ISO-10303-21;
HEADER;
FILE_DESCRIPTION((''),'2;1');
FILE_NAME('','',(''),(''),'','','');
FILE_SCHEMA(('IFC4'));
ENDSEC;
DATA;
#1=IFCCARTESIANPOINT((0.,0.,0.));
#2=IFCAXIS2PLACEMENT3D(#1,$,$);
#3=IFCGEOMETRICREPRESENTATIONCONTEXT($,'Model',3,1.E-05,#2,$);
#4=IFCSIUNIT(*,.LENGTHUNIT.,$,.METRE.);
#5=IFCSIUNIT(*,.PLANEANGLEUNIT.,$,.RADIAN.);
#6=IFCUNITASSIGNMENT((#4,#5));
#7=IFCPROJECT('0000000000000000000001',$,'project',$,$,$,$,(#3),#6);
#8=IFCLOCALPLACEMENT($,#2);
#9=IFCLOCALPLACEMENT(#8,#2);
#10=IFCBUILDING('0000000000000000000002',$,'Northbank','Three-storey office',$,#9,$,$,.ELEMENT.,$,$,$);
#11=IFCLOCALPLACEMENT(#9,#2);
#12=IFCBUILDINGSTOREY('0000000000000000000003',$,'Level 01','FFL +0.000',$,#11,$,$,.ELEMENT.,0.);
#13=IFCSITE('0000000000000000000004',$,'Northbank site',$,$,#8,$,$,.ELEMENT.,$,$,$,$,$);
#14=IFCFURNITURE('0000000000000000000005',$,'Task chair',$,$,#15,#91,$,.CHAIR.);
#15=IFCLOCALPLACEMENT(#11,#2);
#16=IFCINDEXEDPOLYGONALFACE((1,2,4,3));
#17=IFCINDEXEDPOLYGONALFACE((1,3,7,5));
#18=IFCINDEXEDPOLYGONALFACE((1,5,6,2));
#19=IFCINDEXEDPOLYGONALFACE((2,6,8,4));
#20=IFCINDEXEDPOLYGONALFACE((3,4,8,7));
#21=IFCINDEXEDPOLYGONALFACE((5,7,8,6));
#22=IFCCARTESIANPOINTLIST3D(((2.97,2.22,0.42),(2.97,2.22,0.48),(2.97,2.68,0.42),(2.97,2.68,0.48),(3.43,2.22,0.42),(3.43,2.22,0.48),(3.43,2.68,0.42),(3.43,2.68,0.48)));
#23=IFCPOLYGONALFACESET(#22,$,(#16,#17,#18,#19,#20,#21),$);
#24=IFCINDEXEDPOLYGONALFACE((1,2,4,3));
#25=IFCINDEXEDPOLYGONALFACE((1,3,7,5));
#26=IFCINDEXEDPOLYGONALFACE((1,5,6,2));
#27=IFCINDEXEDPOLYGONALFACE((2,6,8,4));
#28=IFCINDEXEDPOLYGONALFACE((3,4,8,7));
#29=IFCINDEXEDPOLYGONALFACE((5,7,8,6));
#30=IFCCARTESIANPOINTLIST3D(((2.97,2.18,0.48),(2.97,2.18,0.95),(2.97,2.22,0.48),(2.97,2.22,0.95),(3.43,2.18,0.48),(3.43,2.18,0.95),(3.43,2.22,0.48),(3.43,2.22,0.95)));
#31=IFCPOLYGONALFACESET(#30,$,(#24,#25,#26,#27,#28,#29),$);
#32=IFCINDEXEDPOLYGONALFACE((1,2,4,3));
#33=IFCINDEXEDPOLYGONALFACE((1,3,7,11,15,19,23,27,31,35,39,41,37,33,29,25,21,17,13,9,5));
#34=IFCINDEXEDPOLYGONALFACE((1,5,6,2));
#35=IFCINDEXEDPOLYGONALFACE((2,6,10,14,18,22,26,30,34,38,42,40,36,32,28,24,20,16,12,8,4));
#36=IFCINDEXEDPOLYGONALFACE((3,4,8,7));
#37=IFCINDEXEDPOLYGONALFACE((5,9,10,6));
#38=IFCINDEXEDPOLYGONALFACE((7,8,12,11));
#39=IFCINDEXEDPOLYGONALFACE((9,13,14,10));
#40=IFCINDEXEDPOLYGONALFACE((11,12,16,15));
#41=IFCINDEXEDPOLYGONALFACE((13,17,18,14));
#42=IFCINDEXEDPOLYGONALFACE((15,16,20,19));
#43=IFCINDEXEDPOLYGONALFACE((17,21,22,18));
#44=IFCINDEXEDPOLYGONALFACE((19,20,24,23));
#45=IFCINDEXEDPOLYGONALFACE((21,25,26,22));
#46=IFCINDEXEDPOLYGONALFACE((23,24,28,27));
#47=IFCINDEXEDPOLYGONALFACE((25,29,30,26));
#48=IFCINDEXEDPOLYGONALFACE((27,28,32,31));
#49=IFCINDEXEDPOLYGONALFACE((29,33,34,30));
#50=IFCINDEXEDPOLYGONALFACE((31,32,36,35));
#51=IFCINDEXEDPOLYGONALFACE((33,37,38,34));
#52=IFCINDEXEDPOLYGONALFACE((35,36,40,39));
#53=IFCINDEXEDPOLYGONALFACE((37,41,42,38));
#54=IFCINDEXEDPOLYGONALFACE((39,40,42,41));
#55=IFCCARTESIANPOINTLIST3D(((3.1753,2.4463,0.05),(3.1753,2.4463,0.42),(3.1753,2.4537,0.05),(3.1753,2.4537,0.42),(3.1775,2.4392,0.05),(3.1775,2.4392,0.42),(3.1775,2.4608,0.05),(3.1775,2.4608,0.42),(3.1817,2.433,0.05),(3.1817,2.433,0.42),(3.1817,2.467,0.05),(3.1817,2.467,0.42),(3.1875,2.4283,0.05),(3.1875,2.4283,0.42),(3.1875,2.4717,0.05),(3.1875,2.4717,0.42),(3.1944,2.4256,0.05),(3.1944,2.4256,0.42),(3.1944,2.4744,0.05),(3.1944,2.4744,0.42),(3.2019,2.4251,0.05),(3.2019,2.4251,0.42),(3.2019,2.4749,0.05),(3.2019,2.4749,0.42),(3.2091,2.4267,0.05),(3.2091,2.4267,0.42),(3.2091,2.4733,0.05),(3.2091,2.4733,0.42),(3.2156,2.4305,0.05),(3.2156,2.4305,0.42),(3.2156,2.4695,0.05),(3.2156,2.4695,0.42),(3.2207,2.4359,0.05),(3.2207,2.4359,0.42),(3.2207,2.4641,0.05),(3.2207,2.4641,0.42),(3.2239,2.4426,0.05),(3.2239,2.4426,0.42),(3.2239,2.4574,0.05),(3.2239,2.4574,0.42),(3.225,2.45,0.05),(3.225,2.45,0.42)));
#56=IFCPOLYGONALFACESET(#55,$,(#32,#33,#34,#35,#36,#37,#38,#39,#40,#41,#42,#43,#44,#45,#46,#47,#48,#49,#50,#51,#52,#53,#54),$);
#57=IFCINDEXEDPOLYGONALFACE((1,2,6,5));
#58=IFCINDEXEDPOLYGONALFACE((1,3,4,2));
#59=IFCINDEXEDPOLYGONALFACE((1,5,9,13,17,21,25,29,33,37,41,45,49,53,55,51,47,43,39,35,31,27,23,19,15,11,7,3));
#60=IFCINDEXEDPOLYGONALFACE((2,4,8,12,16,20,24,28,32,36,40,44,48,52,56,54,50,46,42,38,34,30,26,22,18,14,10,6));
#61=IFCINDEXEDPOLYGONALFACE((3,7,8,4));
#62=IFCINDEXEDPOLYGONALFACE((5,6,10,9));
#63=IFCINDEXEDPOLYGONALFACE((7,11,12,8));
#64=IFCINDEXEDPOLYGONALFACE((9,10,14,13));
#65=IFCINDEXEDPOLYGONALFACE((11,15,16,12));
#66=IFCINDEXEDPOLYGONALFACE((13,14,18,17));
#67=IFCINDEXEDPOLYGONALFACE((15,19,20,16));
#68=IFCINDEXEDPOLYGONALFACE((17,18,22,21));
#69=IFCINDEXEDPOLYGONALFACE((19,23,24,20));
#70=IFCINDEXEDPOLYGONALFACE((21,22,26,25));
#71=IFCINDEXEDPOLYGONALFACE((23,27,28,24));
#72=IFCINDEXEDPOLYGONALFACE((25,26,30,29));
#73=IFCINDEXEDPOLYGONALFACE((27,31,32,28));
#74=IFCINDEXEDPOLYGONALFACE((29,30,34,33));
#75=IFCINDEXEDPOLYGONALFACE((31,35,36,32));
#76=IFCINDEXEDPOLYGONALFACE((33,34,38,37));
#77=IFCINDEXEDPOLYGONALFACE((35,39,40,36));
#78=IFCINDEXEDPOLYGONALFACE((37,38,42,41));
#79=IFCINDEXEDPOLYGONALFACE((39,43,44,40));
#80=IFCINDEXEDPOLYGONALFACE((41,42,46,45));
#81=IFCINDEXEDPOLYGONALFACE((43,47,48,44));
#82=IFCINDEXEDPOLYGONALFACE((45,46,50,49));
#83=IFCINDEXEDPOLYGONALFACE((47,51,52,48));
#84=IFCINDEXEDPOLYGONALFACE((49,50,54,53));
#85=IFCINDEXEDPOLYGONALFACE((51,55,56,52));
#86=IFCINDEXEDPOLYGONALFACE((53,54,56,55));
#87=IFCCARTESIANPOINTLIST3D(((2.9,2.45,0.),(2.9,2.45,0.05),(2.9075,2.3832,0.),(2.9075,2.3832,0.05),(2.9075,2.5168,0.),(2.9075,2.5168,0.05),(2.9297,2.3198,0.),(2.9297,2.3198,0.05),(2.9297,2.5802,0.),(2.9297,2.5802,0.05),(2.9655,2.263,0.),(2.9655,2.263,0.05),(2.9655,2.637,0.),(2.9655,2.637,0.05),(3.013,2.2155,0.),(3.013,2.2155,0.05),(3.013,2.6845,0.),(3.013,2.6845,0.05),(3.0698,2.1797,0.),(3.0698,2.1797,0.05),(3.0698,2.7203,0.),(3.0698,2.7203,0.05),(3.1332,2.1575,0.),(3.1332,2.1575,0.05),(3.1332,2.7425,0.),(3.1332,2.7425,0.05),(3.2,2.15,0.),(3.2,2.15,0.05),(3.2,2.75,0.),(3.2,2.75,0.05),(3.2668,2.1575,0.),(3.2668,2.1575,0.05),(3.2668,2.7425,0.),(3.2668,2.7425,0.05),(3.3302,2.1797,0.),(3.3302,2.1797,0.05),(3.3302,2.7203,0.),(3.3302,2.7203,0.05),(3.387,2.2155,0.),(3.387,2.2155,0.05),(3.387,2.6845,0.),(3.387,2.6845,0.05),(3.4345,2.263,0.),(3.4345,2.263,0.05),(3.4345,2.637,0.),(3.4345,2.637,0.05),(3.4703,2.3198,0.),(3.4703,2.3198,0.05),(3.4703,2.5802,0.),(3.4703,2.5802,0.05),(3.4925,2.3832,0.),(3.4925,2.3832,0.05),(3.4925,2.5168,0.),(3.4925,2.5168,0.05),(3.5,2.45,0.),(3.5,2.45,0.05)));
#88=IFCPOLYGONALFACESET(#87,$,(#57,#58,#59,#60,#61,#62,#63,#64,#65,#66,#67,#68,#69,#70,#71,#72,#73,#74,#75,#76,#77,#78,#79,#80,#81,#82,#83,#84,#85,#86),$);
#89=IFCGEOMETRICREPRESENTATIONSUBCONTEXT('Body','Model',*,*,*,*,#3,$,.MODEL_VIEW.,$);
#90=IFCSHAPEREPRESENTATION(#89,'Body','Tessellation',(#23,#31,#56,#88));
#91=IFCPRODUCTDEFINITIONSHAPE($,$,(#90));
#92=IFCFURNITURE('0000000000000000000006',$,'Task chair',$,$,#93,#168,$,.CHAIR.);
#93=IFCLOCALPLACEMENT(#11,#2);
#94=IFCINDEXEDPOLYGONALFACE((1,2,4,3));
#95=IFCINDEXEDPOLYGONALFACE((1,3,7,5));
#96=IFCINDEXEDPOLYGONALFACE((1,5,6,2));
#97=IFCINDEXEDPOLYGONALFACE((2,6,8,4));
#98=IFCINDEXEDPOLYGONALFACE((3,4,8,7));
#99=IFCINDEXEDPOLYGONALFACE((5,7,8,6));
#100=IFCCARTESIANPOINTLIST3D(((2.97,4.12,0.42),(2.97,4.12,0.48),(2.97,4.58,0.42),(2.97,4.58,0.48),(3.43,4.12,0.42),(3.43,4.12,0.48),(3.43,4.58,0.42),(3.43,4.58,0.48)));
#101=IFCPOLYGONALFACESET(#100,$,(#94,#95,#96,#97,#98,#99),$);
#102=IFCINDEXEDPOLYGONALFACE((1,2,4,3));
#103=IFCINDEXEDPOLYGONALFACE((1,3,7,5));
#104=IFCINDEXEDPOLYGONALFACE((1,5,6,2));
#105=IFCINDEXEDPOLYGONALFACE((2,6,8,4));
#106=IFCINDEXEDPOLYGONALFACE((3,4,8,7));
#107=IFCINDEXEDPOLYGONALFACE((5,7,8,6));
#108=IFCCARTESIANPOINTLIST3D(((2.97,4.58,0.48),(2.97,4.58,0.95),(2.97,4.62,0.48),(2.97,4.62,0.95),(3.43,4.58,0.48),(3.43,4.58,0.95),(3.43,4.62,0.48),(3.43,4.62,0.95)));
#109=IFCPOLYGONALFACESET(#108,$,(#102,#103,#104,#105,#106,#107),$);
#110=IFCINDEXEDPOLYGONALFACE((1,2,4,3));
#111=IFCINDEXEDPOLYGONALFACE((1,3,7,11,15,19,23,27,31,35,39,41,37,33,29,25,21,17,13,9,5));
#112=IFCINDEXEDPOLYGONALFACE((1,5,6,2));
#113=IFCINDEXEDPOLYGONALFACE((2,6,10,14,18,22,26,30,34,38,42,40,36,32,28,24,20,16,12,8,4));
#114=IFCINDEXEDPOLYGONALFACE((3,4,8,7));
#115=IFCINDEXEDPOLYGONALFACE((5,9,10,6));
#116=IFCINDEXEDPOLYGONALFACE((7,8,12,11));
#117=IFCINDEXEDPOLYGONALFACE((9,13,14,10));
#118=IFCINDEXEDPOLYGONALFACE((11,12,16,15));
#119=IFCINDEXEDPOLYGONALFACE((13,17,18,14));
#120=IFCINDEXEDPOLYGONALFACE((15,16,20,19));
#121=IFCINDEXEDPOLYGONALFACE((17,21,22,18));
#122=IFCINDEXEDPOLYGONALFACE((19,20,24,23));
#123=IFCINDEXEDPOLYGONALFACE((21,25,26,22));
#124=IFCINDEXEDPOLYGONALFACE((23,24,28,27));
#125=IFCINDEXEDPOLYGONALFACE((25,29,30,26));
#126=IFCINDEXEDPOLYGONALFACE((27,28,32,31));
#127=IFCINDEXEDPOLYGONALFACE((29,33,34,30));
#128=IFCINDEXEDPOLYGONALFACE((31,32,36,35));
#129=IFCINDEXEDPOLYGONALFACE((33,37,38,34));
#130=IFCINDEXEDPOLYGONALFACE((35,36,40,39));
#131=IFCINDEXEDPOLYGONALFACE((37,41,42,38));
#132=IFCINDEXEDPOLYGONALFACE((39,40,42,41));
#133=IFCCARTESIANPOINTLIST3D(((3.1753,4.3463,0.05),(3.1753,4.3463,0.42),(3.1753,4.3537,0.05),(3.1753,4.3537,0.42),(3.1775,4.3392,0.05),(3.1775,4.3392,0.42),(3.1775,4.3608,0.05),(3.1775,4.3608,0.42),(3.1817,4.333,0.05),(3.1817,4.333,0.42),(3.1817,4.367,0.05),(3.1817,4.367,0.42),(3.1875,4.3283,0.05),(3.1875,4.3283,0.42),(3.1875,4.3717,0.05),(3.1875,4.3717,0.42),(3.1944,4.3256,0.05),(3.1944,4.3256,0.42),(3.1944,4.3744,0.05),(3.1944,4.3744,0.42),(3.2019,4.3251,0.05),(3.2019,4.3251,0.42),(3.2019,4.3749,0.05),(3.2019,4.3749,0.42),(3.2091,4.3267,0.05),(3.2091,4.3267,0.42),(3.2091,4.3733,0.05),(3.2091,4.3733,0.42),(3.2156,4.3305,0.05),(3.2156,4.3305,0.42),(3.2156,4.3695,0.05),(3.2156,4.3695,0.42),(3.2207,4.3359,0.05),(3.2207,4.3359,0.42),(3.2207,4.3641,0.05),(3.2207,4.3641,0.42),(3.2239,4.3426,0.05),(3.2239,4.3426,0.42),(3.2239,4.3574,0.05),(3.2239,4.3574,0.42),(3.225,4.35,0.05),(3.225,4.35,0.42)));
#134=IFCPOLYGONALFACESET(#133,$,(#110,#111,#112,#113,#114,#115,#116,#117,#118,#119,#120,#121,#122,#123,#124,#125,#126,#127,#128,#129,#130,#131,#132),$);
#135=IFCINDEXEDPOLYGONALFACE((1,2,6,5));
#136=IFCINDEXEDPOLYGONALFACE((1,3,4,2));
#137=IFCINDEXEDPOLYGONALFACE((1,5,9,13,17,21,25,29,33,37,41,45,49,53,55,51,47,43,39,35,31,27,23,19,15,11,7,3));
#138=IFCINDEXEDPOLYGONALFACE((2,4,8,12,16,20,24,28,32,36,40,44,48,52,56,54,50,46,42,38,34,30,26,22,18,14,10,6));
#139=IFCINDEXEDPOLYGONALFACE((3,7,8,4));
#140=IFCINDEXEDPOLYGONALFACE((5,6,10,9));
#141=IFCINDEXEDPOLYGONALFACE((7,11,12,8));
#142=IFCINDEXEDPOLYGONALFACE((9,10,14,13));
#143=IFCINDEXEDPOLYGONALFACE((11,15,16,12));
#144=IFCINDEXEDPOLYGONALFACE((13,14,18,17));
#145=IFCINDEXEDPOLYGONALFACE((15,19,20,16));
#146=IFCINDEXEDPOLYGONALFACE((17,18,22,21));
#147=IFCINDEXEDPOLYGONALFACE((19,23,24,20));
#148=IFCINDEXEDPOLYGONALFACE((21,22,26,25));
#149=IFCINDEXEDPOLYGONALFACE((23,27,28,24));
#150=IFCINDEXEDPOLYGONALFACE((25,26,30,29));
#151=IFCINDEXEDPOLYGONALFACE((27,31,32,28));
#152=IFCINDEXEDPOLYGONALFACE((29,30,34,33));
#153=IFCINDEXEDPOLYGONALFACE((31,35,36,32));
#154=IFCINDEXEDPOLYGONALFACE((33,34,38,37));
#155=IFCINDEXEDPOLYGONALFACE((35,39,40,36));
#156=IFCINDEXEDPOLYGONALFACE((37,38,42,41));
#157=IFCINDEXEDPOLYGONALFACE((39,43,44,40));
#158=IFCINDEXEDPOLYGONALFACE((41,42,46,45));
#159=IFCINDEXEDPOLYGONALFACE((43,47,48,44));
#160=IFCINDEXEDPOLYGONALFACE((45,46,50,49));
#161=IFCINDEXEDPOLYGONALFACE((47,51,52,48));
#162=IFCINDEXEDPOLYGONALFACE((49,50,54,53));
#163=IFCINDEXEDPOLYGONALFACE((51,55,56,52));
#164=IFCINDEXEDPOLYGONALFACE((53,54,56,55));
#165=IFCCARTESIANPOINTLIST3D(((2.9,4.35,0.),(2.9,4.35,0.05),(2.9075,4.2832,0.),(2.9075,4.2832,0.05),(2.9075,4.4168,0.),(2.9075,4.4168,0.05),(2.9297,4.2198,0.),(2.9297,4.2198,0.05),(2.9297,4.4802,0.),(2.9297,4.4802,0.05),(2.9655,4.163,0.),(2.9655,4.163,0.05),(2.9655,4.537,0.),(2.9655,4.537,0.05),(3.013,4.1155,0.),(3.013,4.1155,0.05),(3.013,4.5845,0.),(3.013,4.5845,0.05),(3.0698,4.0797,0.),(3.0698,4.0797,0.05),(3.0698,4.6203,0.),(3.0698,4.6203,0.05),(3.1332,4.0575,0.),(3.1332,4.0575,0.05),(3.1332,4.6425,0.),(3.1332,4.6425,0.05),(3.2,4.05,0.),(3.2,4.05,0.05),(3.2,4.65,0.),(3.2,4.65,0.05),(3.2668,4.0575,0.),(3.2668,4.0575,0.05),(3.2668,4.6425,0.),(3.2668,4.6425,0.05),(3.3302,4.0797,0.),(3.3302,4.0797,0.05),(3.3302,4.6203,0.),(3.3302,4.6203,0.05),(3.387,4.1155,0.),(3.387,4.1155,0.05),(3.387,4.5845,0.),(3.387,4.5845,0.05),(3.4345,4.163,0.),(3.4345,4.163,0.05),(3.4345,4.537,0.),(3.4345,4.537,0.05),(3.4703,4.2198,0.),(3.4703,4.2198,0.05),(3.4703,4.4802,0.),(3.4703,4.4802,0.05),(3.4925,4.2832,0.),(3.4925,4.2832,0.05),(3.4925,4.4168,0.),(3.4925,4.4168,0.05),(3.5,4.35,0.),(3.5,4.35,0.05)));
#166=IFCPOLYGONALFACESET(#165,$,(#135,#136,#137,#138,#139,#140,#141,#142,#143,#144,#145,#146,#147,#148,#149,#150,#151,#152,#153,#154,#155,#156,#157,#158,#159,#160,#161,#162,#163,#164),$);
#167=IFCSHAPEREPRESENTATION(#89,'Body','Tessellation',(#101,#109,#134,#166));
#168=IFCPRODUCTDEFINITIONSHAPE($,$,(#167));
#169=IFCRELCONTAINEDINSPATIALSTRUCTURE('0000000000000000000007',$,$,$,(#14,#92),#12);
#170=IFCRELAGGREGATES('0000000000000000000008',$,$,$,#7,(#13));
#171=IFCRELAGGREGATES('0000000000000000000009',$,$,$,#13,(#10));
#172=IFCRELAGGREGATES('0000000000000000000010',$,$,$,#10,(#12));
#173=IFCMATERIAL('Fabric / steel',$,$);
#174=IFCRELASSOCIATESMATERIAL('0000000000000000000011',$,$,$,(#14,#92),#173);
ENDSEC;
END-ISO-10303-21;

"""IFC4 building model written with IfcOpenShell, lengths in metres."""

from ifc_helpers import new_model, si_unit, frame, origin, place, context, subcontext, project, spatial, rectangle, circle, extrude, material, element, save


model = new_model("IFC4")

# Units and contexts
model_context = context("Model", 3, precision=1e-05, world=origin())
body_context = subcontext(model_context, "Body", "Model", "MODEL_VIEW")
ifc_project = project(units=[si_unit("LENGTHUNIT", "METRE"), si_unit("PLANEANGLEUNIT", "RADIAN")], contexts=[model_context])

# Site, building, storey
site_placement = place(None, origin())
site = spatial("IfcSite", under=ifc_project, at=site_placement, Name="Northbank site", CompositionType="ELEMENT")
building_placement = place(site_placement, origin())
building = spatial("IfcBuilding", under=site, at=building_placement, Name="Northbank", Description="Three-storey office", CompositionType="ELEMENT")
storey_placement = place(building_placement, origin())
storey = spatial("IfcBuildingStorey", under=building, at=storey_placement, Name="Level 01", Description="FFL +0.000", CompositionType="ELEMENT", Elevation=0.0)

# Furniture
ifc_material_1 = material(Name="Fabric / steel")
furniture_1_placement = place(storey_placement, origin())
element("IfcFurniture", 1, at=furniture_1_placement, inside=storey, material=ifc_material_1, Name="Task chair", PredefinedType="CHAIR", context=body_context, shape_type="SweptSolid", body=[
    extrude(rectangle(XDim=0.46, YDim=0.46), frame((3.2, 2.45, 0.42)), (0.0, 0.0, 1.0), 0.06),
    extrude(rectangle(XDim=0.46, YDim=0.04), frame((3.2, 2.2, 0.48)), (0.0, 0.0, 1.0), 0.47),
    extrude(circle(Radius=0.025), frame((3.2, 2.45, 0.05), z_axis=(0.0, 0.0, 1.0), x_axis=(1.0, 0.0, 0.0)), (0.0, 0.0, 1.0), 0.37),
    extrude(circle(Radius=0.3), frame((3.2, 2.45, 0.0), z_axis=(0.0, 0.0, 1.0), x_axis=(1.0, 0.0, 0.0)), (0.0, 0.0, 1.0), 0.05),
])
furniture_2_placement = place(storey_placement, origin())
element("IfcFurniture", 2, at=furniture_2_placement, inside=storey, material=ifc_material_1, Name="Task chair", PredefinedType="CHAIR", context=body_context, shape_type="SweptSolid", body=[
    extrude(rectangle(XDim=0.46, YDim=0.46), frame((3.2, 4.35, 0.42)), (0.0, 0.0, 1.0), 0.06),
    extrude(rectangle(XDim=0.46, YDim=0.04), frame((3.2, 4.6, 0.48)), (0.0, 0.0, 1.0), 0.47),
    extrude(circle(Radius=0.025), frame((3.2, 4.35, 0.05), z_axis=(0.0, 0.0, 1.0), x_axis=(1.0, 0.0, 0.0)), (0.0, 0.0, 1.0), 0.37),
    extrude(circle(Radius=0.3), frame((3.2, 4.35, 0.0), z_axis=(0.0, 0.0, 1.0), x_axis=(1.0, 0.0, 0.0)), (0.0, 0.0, 1.0), 0.05),
])

save(model, "model.ifc")
